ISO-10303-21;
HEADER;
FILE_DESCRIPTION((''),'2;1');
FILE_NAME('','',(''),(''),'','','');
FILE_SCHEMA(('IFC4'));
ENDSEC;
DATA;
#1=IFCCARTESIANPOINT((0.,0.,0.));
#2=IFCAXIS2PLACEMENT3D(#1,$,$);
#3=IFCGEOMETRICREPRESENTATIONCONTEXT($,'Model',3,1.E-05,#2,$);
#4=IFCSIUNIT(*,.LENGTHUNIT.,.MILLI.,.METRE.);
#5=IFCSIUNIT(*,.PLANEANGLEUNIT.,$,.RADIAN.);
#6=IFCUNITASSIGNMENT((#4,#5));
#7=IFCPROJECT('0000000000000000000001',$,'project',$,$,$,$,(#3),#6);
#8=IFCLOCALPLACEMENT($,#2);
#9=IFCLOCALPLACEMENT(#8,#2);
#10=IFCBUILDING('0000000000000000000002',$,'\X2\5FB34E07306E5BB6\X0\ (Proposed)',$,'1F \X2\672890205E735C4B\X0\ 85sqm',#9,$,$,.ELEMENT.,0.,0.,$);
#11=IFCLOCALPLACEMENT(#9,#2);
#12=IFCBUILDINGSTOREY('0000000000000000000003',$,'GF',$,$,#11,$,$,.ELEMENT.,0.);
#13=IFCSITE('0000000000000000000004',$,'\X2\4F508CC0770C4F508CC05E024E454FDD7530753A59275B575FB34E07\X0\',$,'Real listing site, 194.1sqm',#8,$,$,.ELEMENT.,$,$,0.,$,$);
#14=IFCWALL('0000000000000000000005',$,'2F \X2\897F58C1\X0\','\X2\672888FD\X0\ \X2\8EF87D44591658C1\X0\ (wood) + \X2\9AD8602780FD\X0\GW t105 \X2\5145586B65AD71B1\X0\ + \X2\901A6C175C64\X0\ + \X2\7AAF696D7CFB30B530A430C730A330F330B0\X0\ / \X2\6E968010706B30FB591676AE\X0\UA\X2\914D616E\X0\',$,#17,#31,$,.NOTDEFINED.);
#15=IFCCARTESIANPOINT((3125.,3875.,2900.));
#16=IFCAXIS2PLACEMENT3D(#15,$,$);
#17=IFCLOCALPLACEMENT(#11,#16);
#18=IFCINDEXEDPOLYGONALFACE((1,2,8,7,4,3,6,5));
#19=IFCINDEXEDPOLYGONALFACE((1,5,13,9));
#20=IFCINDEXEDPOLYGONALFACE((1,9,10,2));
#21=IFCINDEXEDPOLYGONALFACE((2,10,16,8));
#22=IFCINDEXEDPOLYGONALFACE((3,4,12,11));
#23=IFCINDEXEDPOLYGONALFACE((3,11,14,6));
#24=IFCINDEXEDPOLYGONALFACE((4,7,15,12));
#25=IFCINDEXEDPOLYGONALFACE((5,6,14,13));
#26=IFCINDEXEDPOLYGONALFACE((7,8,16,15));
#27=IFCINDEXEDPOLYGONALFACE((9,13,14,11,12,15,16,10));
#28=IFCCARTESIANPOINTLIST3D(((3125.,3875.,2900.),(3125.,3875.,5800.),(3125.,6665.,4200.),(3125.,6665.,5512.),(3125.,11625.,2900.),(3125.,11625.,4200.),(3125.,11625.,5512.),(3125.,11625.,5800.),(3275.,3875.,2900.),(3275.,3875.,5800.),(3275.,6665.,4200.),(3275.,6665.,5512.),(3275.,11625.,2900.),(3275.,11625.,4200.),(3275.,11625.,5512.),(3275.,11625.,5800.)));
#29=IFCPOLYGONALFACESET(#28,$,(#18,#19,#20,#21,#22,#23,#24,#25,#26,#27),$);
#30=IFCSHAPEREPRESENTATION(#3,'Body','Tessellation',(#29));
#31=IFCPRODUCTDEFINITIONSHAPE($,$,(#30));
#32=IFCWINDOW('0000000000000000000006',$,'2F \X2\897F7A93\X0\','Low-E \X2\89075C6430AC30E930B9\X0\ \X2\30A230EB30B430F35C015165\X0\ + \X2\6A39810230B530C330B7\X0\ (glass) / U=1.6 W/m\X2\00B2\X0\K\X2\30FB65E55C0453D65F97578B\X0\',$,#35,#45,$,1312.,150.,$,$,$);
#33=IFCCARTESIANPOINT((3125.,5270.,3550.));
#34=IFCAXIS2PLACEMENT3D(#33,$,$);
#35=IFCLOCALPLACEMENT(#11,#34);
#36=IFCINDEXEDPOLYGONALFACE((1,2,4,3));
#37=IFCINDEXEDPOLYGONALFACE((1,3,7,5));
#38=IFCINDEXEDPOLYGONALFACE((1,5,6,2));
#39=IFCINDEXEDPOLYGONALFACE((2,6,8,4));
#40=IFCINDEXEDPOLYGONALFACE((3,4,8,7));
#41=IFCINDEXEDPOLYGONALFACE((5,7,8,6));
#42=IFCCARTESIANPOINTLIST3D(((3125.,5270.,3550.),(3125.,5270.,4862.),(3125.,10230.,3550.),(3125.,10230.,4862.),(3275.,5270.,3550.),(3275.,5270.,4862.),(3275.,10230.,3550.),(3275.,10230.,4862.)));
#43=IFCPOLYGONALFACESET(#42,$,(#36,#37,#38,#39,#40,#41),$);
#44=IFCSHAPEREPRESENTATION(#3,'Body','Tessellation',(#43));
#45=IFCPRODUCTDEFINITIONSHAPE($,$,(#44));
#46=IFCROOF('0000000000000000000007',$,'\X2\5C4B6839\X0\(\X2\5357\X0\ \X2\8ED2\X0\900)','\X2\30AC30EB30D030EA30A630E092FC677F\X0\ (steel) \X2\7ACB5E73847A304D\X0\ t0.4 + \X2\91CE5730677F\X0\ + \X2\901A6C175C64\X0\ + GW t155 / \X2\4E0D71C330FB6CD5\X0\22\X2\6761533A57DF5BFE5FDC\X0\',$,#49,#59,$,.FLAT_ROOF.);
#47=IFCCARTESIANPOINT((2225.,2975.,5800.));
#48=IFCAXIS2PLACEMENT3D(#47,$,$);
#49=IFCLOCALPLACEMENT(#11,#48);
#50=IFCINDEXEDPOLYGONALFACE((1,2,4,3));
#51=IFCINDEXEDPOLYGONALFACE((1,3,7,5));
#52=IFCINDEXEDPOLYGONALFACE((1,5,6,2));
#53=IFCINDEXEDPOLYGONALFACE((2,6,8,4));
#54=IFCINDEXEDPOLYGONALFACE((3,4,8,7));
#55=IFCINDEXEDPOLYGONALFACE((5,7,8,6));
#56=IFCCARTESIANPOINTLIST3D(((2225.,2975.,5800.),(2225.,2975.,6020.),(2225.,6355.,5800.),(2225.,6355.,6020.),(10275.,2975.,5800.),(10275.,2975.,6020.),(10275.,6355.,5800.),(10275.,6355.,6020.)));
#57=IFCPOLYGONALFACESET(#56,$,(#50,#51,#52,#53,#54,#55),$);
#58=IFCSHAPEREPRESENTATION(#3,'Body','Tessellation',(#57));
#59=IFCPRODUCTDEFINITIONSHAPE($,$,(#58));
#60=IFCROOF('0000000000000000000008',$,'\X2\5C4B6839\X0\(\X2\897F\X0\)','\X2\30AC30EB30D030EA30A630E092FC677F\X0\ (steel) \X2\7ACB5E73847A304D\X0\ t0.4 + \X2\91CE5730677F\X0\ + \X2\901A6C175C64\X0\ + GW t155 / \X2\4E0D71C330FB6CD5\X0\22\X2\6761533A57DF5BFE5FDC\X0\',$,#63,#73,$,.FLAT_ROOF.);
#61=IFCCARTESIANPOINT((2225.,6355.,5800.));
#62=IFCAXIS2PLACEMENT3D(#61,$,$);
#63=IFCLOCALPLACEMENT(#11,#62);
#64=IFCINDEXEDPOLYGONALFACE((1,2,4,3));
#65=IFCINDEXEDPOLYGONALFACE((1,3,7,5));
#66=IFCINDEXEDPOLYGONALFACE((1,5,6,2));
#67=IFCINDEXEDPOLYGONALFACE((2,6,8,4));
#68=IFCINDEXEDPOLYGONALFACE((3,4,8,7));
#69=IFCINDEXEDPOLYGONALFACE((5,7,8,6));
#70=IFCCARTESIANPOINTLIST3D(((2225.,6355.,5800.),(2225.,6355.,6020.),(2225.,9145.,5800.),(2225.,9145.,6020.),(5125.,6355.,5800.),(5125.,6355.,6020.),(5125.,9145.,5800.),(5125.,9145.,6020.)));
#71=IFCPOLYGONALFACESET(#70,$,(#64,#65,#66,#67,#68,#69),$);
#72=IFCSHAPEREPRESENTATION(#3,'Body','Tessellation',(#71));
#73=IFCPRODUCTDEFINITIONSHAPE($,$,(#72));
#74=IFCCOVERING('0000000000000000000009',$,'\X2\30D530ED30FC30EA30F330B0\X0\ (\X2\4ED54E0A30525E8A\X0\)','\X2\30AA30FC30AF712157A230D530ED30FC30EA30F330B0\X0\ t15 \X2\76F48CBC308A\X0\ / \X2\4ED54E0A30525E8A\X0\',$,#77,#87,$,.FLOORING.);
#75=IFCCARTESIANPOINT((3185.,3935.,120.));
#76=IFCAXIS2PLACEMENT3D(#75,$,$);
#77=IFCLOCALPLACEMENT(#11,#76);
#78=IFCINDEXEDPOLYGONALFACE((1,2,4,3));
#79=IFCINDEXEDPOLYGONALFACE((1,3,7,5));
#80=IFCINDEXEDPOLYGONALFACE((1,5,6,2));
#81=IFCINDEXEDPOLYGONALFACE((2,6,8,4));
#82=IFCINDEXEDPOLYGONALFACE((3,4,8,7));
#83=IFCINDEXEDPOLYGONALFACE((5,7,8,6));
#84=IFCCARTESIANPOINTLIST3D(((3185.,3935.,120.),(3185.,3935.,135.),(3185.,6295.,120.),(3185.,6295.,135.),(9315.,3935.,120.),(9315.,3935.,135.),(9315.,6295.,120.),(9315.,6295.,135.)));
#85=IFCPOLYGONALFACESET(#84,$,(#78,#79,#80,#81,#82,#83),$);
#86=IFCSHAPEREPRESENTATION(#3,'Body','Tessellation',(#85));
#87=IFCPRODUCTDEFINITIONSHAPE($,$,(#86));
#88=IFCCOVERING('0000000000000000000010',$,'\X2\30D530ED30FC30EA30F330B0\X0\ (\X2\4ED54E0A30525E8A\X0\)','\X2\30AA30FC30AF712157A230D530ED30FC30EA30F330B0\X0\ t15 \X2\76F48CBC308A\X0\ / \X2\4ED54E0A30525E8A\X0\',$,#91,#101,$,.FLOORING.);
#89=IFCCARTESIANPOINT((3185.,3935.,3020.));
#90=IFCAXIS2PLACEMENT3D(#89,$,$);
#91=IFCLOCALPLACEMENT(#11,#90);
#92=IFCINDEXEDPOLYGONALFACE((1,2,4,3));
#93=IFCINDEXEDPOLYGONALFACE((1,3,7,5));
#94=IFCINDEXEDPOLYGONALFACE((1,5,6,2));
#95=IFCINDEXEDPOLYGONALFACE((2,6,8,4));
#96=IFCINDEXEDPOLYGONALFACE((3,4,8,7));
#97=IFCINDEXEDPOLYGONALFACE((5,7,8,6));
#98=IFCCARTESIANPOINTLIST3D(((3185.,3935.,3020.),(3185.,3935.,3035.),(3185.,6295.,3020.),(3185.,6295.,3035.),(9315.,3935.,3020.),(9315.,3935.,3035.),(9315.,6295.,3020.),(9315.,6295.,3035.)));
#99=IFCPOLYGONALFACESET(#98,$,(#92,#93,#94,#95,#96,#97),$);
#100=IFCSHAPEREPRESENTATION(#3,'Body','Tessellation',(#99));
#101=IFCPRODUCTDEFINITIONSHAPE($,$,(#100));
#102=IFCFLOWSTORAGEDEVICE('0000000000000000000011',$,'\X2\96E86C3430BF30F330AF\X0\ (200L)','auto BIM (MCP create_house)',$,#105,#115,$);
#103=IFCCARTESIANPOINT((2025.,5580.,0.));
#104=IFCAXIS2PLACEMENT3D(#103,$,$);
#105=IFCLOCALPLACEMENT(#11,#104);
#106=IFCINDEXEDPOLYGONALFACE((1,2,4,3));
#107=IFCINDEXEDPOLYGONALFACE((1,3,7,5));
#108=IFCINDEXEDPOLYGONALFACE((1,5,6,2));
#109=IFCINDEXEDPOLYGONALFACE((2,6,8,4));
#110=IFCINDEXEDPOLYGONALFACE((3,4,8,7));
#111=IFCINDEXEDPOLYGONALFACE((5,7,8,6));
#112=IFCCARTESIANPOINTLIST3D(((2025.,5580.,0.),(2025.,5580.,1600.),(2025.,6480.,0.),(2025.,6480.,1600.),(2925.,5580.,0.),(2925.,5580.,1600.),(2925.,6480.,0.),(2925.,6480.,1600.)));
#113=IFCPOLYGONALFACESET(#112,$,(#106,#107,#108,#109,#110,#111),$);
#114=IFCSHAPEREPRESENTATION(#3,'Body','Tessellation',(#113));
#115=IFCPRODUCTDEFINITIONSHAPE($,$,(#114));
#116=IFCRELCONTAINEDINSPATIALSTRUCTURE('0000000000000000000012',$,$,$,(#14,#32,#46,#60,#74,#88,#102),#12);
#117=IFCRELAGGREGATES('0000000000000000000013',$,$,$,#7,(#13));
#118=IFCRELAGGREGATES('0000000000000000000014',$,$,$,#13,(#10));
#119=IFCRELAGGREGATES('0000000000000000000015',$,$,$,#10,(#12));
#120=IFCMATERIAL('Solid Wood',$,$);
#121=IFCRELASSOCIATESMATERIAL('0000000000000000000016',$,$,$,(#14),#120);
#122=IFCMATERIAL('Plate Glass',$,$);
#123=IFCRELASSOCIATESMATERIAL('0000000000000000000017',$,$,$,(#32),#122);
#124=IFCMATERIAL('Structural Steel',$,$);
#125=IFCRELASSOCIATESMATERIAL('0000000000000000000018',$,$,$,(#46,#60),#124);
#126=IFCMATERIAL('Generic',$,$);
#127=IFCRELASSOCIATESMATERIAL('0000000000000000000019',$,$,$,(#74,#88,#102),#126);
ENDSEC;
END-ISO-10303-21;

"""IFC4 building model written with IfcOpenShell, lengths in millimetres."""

from ifc_helpers import new_model, si_unit, frame, frame_2d, origin, place, context, project, spatial, rectangle, extrude, material, element, fill, save


model = new_model("IFC4")

# Units and contexts
model_context = context("Model", 3, precision=1e-05, world=origin())
ifc_project = project(units=[si_unit("LENGTHUNIT", "METRE", prefix="MILLI"), si_unit("PLANEANGLEUNIT", "RADIAN")], contexts=[model_context])

# Site, building, storey
site_placement = place(None, origin())
site = spatial("IfcSite", under=ifc_project, at=site_placement, Name="佐賀県佐賀市久保田町大字徳万", ObjectType="Real listing site, 194.1sqm", CompositionType="ELEMENT", RefElevation=0.0)
building_placement = place(site_placement, origin())
building = spatial("IfcBuilding", under=site, at=building_placement, Name="徳万の家 (Proposed)", ObjectType="1F 木造平屋 85sqm", CompositionType="ELEMENT", ElevationOfRefHeight=0.0, ElevationOfTerrain=0.0)
storey_placement = place(building_placement, origin())
storey = spatial("IfcBuildingStorey", under=building, at=storey_placement, Name="GF", CompositionType="ELEMENT", Elevation=0.0)

# Shared definitions
ifc_material_1 = material(Name="Solid Wood")
ifc_material_2 = material(Name="Generic")

# Shared definitions
ifc_material_3 = material(Name="Plate Glass")

# Wall, opening, window
wall_1_placement = place(storey_placement, frame((3125.0, 3875.0, 2900.0)))
wall_1 = element("IfcWall", 1, at=wall_1_placement, inside=storey, material=ifc_material_1, Name="2F 西壁", Description="木製 軸組外壁 (wood) + 高性能GW t105 充填断熱 + 通気層 + 窯業系サイディング / 準耐火・外皮UA配慮", PredefinedType="NOTDEFINED", context=model_context, shape_type="SweptSolid", body=[
    extrude(rectangle(XDim=150.0, YDim=7750.0, at=frame_2d((75.0, 3875.0))), frame((3125.0, 3875.0, 2900.0)), (0.0, 0.0, 1.0), 2900.0),
])
opening_1_placement = place(storey_placement, frame((3125.0, 5270.0, 3550.0)))
opening_1 = element("IfcOpeningElement", 2, at=opening_1_placement, cuts=wall_1, PredefinedType="NOTDEFINED", context=model_context, shape_type="SweptSolid", body=[
    extrude(rectangle(XDim=150.0, YDim=4960.0, at=frame_2d((75.0, 2480.0))), frame((3125.0, 5270.0, 3550.0)), (0.0, 0.0, 1.0), 1312.0),
])
window_1_placement = place(storey_placement, frame((3125.0, 5270.0, 3550.0)))
window_1 = element("IfcWindow", 3, at=window_1_placement, inside=storey, material=ifc_material_3, Name="2F 西窓", Description="Low-E 複層ガラス アルゴン封入 + 樹脂サッシ (glass) / U=1.6 W/m²K・日射取得型", OverallHeight=1312.0, OverallWidth=150.0, context=model_context, shape_type="SweptSolid", body=[
    extrude(rectangle(XDim=150.0, YDim=4960.0, at=frame_2d((75.0, 2480.0))), frame((3125.0, 5270.0, 3550.0)), (0.0, 0.0, 1.0), 1312.0),
])
fill(opening_1, window_1)

# Roofs
ifc_material_4 = material(Name="Structural Steel")
roof_1_placement = place(storey_placement, frame((2225.0, 2975.0, 5800.0)))
element("IfcRoof", 4, at=roof_1_placement, inside=storey, material=ifc_material_4, Name="屋根(南 軒900)", Description="ガルバリウム鋼板 (steel) 立平葺き t0.4 + 野地板 + 通気層 + GW t155 / 不燃・法22条区域対応", PredefinedType="FLAT_ROOF", context=model_context, shape_type="SweptSolid", body=[
    extrude(rectangle(XDim=8050.0, YDim=3380.0, at=frame_2d((4025.0, 1690.0))), frame((2225.0, 2975.0, 5800.0)), (0.0, 0.0, 1.0), 220.0),
])
roof_2_placement = place(storey_placement, frame((2225.0, 6355.0, 5800.0)))
element("IfcRoof", 5, at=roof_2_placement, inside=storey, material=ifc_material_4, Name="屋根(西)", Description="ガルバリウム鋼板 (steel) 立平葺き t0.4 + 野地板 + 通気層 + GW t155 / 不燃・法22条区域対応", PredefinedType="FLAT_ROOF", context=model_context, shape_type="SweptSolid", body=[
    extrude(rectangle(XDim=2900.0, YDim=2790.0, at=frame_2d((1450.0, 1395.0))), frame((2225.0, 6355.0, 5800.0)), (0.0, 0.0, 1.0), 220.0),
])

# Coverings
covering_1_placement = place(storey_placement, frame((3185.0, 3935.0, 120.0)))
element("IfcCovering", 6, at=covering_1_placement, inside=storey, material=ifc_material_2, Name="フローリング (仕上げ床)", Description="オーク無垢フローリング t15 直貼り / 仕上げ床", PredefinedType="FLOORING", context=model_context, shape_type="SweptSolid", body=[
    extrude(rectangle(XDim=6130.0, YDim=2360.0, at=frame_2d((3065.0, 1180.0))), frame((3185.0, 3935.0, 120.0)), (0.0, 0.0, 1.0), 15.0),
])
covering_2_placement = place(storey_placement, frame((3185.0, 3935.0, 3020.0)))
element("IfcCovering", 7, at=covering_2_placement, inside=storey, material=ifc_material_2, Name="フローリング (仕上げ床)", Description="オーク無垢フローリング t15 直貼り / 仕上げ床", PredefinedType="FLOORING", context=model_context, shape_type="SweptSolid", body=[
    extrude(rectangle(XDim=6130.0, YDim=2360.0, at=frame_2d((3065.0, 1180.0))), frame((3185.0, 3935.0, 3020.0)), (0.0, 0.0, 1.0), 15.0),
])

# Flow storage device
flow_storage_device_placement = place(storey_placement, frame((2025.0, 5580.0, 0.0)))
element("IfcFlowStorageDevice", 8, at=flow_storage_device_placement, inside=storey, material=ifc_material_2, Name="雨水タンク (200L)", Description="auto BIM (MCP create_house)", context=model_context, shape_type="SweptSolid", body=[
    extrude(rectangle(XDim=900.0, YDim=900.0, at=frame_2d((450.0, 450.0))), frame((2025.0, 5580.0, 0.0)), (0.0, 0.0, 1.0), 1600.0),
])

save(model, "model.ifc")
